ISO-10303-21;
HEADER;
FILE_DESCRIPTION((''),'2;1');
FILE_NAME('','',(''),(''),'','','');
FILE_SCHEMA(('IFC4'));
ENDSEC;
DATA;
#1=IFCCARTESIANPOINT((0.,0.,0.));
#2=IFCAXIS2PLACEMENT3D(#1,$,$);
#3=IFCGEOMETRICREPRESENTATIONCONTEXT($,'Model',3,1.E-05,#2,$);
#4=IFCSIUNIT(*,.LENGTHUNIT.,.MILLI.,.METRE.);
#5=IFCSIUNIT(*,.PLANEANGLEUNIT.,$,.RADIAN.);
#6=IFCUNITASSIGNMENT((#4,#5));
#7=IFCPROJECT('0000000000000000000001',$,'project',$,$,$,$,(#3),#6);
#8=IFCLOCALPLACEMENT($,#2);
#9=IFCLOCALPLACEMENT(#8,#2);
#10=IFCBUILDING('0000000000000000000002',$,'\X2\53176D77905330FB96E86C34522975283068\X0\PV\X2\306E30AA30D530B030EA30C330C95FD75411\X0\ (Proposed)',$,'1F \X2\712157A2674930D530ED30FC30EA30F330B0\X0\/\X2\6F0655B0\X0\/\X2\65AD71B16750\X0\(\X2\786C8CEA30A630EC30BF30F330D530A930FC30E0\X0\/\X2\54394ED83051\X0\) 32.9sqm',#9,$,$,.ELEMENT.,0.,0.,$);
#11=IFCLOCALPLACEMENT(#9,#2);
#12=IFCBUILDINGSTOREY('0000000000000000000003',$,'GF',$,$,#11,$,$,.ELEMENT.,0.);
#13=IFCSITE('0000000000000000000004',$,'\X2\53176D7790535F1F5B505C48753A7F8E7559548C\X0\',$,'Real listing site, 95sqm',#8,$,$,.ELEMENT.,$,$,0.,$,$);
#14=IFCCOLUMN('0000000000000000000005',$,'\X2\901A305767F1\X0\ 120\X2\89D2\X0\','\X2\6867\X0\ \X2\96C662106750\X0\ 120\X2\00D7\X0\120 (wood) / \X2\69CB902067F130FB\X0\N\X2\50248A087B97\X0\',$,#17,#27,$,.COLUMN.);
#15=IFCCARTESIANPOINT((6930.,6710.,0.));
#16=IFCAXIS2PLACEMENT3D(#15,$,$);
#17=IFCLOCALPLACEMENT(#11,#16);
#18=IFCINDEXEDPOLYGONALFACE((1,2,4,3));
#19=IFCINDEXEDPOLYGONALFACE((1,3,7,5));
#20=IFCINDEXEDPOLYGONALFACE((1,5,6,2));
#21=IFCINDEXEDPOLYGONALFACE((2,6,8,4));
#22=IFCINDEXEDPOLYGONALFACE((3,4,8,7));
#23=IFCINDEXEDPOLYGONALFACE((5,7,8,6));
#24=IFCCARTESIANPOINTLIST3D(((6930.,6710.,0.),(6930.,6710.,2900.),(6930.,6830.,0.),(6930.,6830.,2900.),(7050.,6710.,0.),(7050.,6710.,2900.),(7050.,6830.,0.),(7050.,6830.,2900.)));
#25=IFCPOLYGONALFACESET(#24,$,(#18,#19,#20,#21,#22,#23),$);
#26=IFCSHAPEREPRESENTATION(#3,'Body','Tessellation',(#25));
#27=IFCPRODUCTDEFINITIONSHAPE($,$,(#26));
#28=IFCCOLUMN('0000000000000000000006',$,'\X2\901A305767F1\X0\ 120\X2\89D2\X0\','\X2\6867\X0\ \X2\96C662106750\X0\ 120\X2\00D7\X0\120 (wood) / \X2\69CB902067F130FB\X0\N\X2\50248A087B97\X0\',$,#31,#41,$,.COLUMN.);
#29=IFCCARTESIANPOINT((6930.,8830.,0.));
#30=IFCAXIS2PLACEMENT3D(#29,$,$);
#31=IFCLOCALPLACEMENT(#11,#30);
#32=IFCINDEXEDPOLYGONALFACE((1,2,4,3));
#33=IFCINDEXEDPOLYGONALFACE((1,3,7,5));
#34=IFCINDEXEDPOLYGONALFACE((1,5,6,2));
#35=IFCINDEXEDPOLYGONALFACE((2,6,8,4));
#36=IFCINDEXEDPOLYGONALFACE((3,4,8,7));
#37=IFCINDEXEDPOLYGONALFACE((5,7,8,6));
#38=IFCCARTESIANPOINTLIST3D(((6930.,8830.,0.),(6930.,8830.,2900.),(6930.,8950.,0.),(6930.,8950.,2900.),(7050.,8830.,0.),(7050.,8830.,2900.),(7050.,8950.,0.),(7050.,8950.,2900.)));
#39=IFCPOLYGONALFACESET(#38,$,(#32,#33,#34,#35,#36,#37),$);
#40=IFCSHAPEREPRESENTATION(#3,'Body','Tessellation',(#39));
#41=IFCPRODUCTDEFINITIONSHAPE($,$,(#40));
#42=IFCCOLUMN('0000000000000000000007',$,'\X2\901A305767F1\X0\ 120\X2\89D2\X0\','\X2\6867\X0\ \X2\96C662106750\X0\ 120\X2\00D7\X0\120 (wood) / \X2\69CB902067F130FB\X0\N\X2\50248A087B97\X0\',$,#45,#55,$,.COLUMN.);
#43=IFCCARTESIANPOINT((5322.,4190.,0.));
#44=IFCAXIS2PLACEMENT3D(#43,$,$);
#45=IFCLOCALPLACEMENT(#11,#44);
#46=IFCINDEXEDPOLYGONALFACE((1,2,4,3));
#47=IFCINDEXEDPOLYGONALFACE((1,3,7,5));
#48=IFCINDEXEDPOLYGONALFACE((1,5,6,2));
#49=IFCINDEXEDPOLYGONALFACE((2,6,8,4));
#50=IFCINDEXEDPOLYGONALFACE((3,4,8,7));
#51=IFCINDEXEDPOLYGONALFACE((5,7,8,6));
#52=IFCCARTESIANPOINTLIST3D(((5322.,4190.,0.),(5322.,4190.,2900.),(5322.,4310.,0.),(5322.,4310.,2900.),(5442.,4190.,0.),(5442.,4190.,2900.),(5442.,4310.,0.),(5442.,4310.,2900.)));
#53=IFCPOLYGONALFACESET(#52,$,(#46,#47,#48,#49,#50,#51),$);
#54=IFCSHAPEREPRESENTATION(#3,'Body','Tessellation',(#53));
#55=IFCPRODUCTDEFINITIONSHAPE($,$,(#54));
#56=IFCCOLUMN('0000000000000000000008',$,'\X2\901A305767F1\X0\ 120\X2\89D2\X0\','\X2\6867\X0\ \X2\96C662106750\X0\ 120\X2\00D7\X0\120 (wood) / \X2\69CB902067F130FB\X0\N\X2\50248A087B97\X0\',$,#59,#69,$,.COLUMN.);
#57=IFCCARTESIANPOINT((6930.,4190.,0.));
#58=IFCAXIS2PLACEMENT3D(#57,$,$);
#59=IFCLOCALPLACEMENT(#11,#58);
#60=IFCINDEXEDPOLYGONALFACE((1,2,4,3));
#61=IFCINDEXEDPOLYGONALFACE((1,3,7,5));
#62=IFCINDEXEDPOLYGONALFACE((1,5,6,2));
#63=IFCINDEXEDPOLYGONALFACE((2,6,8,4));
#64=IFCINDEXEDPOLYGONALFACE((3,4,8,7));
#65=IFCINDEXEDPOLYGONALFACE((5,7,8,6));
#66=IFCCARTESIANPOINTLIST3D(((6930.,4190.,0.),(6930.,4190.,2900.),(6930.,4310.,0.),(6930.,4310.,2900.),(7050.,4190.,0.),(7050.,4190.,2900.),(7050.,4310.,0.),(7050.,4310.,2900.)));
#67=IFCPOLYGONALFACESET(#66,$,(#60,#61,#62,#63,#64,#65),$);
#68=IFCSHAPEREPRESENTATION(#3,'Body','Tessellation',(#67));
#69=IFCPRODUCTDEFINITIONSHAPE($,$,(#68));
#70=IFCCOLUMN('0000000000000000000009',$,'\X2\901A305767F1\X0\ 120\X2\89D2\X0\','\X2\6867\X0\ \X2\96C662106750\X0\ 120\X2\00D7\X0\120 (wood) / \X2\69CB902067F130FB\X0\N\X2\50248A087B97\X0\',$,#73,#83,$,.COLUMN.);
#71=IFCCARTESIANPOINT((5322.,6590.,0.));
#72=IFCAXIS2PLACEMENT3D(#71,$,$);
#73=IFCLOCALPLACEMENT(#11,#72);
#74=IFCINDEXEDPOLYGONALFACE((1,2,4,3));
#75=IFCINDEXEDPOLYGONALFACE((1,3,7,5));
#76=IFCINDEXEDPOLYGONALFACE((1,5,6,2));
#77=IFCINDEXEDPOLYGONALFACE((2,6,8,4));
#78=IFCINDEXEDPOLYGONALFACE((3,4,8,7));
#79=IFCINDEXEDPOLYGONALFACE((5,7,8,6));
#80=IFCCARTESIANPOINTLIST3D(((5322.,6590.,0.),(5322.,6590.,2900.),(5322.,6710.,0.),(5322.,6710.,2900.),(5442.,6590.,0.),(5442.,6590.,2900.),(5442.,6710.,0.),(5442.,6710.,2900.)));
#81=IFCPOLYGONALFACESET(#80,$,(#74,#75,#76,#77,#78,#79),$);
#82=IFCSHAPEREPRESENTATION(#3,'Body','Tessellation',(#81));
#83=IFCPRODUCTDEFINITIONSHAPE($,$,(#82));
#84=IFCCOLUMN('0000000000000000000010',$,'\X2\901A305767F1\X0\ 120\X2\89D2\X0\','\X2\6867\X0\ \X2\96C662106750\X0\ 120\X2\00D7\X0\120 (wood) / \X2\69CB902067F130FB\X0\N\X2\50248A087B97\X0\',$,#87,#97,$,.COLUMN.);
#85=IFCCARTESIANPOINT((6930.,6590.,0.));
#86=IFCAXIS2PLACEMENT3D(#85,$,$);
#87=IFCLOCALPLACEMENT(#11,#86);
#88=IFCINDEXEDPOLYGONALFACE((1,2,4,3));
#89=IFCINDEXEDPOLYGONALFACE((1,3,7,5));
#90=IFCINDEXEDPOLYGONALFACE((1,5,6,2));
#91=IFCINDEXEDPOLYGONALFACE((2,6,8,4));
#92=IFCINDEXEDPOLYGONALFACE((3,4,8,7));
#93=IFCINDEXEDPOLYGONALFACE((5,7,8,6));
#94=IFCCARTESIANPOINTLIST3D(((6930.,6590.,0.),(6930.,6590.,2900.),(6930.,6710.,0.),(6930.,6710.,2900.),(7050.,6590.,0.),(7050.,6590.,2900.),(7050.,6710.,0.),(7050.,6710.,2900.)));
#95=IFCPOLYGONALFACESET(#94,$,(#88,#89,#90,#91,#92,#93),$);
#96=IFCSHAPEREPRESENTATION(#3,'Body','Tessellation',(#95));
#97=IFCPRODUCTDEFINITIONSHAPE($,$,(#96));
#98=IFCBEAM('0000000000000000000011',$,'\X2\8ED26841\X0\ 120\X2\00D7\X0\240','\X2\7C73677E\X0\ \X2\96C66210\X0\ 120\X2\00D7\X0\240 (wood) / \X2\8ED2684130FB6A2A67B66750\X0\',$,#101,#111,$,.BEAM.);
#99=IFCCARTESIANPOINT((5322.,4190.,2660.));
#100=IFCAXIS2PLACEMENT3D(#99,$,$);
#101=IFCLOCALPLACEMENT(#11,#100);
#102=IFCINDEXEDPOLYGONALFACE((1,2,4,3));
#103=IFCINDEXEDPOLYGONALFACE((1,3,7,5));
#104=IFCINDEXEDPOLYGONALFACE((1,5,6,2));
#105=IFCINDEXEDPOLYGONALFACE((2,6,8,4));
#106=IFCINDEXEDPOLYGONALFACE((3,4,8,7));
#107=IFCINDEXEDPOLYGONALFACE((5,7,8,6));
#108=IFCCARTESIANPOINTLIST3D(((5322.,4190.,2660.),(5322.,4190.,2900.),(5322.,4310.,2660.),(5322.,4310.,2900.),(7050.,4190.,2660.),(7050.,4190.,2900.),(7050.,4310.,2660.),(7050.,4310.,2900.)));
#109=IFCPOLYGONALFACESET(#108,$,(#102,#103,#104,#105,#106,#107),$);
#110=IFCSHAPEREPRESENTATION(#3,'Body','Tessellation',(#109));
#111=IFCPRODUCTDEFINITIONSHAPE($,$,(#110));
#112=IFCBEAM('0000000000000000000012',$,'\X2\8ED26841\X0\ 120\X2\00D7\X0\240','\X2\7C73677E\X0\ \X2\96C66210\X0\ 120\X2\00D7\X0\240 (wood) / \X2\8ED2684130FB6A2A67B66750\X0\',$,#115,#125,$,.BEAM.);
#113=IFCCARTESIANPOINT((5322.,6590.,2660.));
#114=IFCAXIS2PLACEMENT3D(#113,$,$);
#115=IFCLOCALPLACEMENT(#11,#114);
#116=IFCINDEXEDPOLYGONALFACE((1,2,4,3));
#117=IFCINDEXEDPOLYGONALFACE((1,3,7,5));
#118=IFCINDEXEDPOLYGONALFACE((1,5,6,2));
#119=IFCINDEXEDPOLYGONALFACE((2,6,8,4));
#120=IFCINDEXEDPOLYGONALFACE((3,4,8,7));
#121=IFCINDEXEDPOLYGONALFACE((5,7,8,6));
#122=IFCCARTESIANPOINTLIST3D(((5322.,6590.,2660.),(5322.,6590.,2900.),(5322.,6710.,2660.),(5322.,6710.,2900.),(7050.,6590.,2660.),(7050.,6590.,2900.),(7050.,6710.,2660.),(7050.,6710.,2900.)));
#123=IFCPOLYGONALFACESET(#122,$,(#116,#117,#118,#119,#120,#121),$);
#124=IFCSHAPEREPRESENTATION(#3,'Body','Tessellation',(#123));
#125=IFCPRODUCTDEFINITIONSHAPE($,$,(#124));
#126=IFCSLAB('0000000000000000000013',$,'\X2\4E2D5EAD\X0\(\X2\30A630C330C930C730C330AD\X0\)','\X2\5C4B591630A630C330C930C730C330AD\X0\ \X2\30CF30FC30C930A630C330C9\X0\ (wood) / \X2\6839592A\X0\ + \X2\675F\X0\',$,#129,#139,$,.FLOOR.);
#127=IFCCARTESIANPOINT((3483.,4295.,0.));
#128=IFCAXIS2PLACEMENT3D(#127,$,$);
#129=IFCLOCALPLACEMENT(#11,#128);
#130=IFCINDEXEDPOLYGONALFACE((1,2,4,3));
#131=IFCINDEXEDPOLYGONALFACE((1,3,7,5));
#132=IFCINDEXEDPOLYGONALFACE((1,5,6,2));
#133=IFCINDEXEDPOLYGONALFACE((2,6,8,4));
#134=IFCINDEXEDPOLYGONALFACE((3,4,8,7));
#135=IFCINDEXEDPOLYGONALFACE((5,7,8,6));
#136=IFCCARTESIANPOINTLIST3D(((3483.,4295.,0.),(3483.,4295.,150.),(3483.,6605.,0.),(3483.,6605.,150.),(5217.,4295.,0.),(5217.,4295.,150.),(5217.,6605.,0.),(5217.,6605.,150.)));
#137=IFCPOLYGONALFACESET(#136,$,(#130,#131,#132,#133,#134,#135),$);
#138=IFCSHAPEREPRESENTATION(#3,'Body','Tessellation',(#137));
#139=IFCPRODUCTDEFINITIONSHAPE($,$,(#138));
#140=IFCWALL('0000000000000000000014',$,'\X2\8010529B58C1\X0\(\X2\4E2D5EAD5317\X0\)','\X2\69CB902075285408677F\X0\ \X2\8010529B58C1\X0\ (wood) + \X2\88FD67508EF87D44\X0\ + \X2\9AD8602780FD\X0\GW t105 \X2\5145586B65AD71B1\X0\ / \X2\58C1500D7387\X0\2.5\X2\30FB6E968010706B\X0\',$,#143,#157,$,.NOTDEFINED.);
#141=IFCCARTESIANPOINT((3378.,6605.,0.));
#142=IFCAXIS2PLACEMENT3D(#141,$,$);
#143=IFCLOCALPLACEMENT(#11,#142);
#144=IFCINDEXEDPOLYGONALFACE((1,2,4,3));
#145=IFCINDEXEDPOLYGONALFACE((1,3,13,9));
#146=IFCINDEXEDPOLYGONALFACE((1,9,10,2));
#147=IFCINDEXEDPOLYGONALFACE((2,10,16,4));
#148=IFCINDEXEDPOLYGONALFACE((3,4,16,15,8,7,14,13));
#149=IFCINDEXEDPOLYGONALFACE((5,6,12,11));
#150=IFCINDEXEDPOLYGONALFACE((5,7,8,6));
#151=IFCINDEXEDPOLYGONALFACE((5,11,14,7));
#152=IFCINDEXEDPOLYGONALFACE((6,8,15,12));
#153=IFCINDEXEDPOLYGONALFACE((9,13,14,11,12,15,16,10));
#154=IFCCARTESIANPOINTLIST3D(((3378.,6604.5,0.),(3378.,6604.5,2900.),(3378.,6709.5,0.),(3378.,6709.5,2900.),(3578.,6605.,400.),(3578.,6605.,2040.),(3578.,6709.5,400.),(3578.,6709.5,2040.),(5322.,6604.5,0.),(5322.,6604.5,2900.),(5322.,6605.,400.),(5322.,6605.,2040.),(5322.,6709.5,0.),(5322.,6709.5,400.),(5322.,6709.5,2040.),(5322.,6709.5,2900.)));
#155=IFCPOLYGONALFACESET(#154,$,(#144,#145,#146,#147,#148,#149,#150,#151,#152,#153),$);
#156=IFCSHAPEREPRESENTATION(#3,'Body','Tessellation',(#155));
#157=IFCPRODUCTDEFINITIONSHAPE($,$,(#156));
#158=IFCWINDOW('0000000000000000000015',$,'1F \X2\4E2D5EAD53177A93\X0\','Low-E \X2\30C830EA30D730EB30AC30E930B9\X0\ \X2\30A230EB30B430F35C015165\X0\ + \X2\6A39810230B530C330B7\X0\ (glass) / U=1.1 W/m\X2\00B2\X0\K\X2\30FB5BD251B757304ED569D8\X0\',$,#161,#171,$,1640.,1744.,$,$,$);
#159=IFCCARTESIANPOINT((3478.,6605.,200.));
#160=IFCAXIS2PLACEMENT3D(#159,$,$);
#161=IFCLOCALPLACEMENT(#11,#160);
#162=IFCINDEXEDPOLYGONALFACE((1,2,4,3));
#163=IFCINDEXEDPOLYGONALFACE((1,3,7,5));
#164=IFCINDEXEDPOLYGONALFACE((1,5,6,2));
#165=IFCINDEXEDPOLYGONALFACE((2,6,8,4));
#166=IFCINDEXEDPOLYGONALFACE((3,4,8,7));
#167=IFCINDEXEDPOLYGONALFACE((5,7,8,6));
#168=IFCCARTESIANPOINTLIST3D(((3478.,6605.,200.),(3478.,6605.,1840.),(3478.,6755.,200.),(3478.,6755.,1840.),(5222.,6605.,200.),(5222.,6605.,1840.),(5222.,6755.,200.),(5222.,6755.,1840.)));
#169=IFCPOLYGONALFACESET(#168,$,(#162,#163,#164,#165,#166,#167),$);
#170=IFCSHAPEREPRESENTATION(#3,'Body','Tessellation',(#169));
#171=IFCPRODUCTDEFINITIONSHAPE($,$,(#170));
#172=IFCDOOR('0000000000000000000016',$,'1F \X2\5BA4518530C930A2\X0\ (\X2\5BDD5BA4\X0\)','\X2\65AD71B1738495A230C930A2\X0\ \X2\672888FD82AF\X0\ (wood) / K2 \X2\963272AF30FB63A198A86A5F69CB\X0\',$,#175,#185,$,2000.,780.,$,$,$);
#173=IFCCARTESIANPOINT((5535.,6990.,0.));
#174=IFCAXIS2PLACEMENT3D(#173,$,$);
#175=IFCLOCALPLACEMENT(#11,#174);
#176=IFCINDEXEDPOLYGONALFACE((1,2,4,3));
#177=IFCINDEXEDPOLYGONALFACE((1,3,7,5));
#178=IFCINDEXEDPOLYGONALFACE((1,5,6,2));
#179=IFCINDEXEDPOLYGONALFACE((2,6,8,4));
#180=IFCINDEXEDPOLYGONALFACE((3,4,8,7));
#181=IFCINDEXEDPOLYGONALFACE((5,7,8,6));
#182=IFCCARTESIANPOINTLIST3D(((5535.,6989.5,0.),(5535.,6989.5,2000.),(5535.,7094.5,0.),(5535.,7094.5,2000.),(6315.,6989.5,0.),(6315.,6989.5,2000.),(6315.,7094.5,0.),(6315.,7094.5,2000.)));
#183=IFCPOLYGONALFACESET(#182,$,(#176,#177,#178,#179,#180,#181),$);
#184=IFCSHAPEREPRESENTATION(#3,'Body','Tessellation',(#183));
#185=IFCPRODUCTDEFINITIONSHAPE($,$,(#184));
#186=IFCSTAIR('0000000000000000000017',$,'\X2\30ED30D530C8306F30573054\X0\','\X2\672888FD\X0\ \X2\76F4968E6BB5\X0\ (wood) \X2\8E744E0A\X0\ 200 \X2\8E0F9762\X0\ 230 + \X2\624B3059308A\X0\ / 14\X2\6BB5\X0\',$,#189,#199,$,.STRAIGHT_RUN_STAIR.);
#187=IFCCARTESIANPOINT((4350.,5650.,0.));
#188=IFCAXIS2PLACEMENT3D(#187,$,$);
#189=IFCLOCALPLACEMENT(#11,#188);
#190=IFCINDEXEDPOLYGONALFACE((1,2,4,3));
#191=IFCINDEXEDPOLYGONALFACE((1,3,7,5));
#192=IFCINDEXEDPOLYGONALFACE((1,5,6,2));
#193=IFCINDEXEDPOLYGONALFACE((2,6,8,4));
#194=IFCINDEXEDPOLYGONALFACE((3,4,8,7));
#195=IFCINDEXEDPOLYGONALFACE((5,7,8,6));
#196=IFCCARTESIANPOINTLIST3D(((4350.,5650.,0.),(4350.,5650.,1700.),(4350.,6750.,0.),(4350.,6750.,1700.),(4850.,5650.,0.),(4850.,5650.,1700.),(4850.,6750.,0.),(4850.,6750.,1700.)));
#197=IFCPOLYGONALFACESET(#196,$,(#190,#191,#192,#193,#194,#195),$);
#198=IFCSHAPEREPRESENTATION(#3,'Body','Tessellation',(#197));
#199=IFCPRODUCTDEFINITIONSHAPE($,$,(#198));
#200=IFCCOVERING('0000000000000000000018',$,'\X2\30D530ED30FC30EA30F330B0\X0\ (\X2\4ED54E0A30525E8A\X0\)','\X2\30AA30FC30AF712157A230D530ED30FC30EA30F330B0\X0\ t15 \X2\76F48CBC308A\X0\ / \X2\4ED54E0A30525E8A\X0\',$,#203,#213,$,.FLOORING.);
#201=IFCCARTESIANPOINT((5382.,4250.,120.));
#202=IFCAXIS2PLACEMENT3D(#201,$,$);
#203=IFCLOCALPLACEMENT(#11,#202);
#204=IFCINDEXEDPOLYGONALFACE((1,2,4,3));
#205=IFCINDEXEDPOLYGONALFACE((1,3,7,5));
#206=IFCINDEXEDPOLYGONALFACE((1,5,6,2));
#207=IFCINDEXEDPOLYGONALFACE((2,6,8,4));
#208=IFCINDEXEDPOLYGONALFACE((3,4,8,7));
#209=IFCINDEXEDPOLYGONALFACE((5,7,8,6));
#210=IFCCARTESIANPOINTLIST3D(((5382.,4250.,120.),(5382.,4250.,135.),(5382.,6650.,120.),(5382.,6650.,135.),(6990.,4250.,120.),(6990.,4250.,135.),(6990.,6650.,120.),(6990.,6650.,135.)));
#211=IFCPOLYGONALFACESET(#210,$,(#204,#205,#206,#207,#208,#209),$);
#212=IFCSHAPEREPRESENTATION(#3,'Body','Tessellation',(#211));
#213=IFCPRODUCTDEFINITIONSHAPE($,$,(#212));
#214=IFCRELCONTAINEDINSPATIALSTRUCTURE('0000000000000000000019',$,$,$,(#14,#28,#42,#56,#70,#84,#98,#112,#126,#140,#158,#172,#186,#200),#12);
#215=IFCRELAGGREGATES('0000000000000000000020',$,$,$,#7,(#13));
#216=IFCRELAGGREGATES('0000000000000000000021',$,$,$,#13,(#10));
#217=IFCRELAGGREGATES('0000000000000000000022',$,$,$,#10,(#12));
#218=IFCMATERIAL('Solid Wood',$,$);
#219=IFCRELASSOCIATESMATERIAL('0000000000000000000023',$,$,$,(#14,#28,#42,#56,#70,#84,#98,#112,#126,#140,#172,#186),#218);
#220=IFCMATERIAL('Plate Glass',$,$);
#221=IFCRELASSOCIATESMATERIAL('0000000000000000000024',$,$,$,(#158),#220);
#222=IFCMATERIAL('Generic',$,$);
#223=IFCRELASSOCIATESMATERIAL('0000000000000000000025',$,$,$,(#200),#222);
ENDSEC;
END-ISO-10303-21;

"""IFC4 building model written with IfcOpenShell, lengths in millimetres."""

from ifc_helpers import new_model, si_unit, frame, frame_2d, origin, place, context, project, spatial, rectangle, extrude, material, element, fill, save


model = new_model("IFC4")

# Units and contexts
model_context = context("Model", 3, precision=1e-05, world=origin())
ifc_project = project(units=[si_unit("LENGTHUNIT", "METRE", prefix="MILLI"), si_unit("PLANEANGLEUNIT", "RADIAN")], contexts=[model_context])

# Site, building, storey
site_placement = place(None, origin())
site = spatial("IfcSite", under=ifc_project, at=site_placement, Name="北海道弟子屈町美留和", ObjectType="Real listing site, 95sqm", CompositionType="ELEMENT", RefElevation=0.0)
building_placement = place(site_placement, origin())
building = spatial("IfcBuilding", under=site, at=building_placement, Name="北海道・雨水利用とPVのオフグリッド志向 (Proposed)", ObjectType="1F 無垢杉フローリング/漆喰/断熱材(硬質ウレタンフォーム/吹付け) 32.9sqm", CompositionType="ELEMENT", ElevationOfRefHeight=0.0, ElevationOfTerrain=0.0)
storey_placement = place(building_placement, origin())
storey = spatial("IfcBuildingStorey", under=building, at=storey_placement, Name="GF", CompositionType="ELEMENT", Elevation=0.0)

# Columns
ifc_material_1 = material(Name="Solid Wood")
column_1_placement = place(storey_placement, frame((6930.0, 6710.0, 0.0)))
element("IfcColumn", 1, at=column_1_placement, inside=storey, material=ifc_material_1, Name="通し柱 120角", Description="桧 集成材 120×120 (wood) / 構造柱・N値計算", PredefinedType="COLUMN", context=model_context, shape_type="SweptSolid", body=[
    extrude(rectangle(XDim=120.0, YDim=120.0, at=frame_2d((60.0, 60.0))), frame((6930.0, 6710.0, 0.0)), (0.0, 0.0, 1.0), 2900.0),
])
column_2_placement = place(storey_placement, frame((6930.0, 8830.0, 0.0)))
element("IfcColumn", 2, at=column_2_placement, inside=storey, material=ifc_material_1, Name="通し柱 120角", Description="桧 集成材 120×120 (wood) / 構造柱・N値計算", PredefinedType="COLUMN", context=model_context, shape_type="SweptSolid", body=[
    extrude(rectangle(XDim=120.0, YDim=120.0, at=frame_2d((60.0, 60.0))), frame((6930.0, 8830.0, 0.0)), (0.0, 0.0, 1.0), 2900.0),
])
column_3_placement = place(storey_placement, frame((5322.0, 4190.0, 0.0)))
element("IfcColumn", 3, at=column_3_placement, inside=storey, material=ifc_material_1, Name="通し柱 120角", Description="桧 集成材 120×120 (wood) / 構造柱・N値計算", PredefinedType="COLUMN", context=model_context, shape_type="SweptSolid", body=[
    extrude(rectangle(XDim=120.0, YDim=120.0, at=frame_2d((60.0, 60.0))), frame((5322.0, 4190.0, 0.0)), (0.0, 0.0, 1.0), 2900.0),
])
column_4_placement = place(storey_placement, frame((6930.0, 4190.0, 0.0)))
element("IfcColumn", 4, at=column_4_placement, inside=storey, material=ifc_material_1, Name="通し柱 120角", Description="桧 集成材 120×120 (wood) / 構造柱・N値計算", PredefinedType="COLUMN", context=model_context, shape_type="SweptSolid", body=[
    extrude(rectangle(XDim=120.0, YDim=120.0, at=frame_2d((60.0, 60.0))), frame((6930.0, 4190.0, 0.0)), (0.0, 0.0, 1.0), 2900.0),
])
column_5_placement = place(storey_placement, frame((5322.0, 6590.0, 0.0)))
element("IfcColumn", 5, at=column_5_placement, inside=storey, material=ifc_material_1, Name="通し柱 120角", Description="桧 集成材 120×120 (wood) / 構造柱・N値計算", PredefinedType="COLUMN", context=model_context, shape_type="SweptSolid", body=[
    extrude(rectangle(XDim=120.0, YDim=120.0, at=frame_2d((60.0, 60.0))), frame((5322.0, 6590.0, 0.0)), (0.0, 0.0, 1.0), 2900.0),
])
column_6_placement = place(storey_placement, frame((6930.0, 6590.0, 0.0)))
element("IfcColumn", 6, at=column_6_placement, inside=storey, material=ifc_material_1, Name="通し柱 120角", Description="桧 集成材 120×120 (wood) / 構造柱・N値計算", PredefinedType="COLUMN", context=model_context, shape_type="SweptSolid", body=[
    extrude(rectangle(XDim=120.0, YDim=120.0, at=frame_2d((60.0, 60.0))), frame((6930.0, 6590.0, 0.0)), (0.0, 0.0, 1.0), 2900.0),
])

# Beams
beam_1_placement = place(storey_placement, frame((5322.0, 4190.0, 2660.0)))
element("IfcBeam", 7, at=beam_1_placement, inside=storey, material=ifc_material_1, Name="軒桁 120×240", Description="米松 集成 120×240 (wood) / 軒桁・横架材", PredefinedType="BEAM", context=model_context, shape_type="SweptSolid", body=[
    extrude(rectangle(XDim=1728.0, YDim=120.0, at=frame_2d((864.0, 60.0))), frame((5322.0, 4190.0, 2660.0)), (0.0, 0.0, 1.0), 240.0),
])
beam_2_placement = place(storey_placement, frame((5322.0, 6590.0, 2660.0)))
element("IfcBeam", 8, at=beam_2_placement, inside=storey, material=ifc_material_1, Name="軒桁 120×240", Description="米松 集成 120×240 (wood) / 軒桁・横架材", PredefinedType="BEAM", context=model_context, shape_type="SweptSolid", body=[
    extrude(rectangle(XDim=1728.0, YDim=120.0, at=frame_2d((864.0, 60.0))), frame((5322.0, 6590.0, 2660.0)), (0.0, 0.0, 1.0), 240.0),
])

# Slab
slab_placement = place(storey_placement, frame((3483.0, 4295.0, 0.0)))
element("IfcSlab", 9, at=slab_placement, inside=storey, material=ifc_material_1, Name="中庭(ウッドデッキ)", Description="屋外ウッドデッキ ハードウッド (wood) / 根太 + 束", PredefinedType="FLOOR", context=model_context, shape_type="SweptSolid", body=[
    extrude(rectangle(XDim=1734.0, YDim=2310.0, at=frame_2d((867.0, 1155.0))), frame((3483.0, 4295.0, 0.0)), (0.0, 0.0, 1.0), 150.0),
])

# Wall, opening, window
wall_1_placement = place(storey_placement, frame((3378.0, 6605.0, 0.0)))
wall_1 = element("IfcWall", 10, at=wall_1_placement, inside=storey, material=ifc_material_1, Name="耐力壁(中庭北)", Description="構造用合板 耐力壁 (wood) + 製材軸組 + 高性能GW t105 充填断熱 / 壁倍率2.5・準耐火", PredefinedType="NOTDEFINED", context=model_context, shape_type="SweptSolid", body=[
    extrude(rectangle(XDim=1944.0, YDim=105.0, at=frame_2d((972.0, 52.0))), frame((3378.0, 6605.0, 0.0)), (0.0, 0.0, 1.0), 2900.0),
])
opening_placement = place(storey_placement, frame((3478.0, 6605.0, 200.0)))
opening = element("IfcOpeningElement", 11, at=opening_placement, cuts=wall_1, PredefinedType="NOTDEFINED", context=model_context, shape_type="SweptSolid", body=[
    extrude(rectangle(XDim=1744.0, YDim=150.0, at=frame_2d((872.0, 75.0))), frame((3478.0, 6605.0, 200.0)), (0.0, 0.0, 1.0), 1640.0),
])
ifc_material_2 = material(Name="Plate Glass")
window_placement = place(storey_placement, frame((3478.0, 6605.0, 200.0)))
window = element("IfcWindow", 12, at=window_placement, inside=storey, material=ifc_material_2, Name="1F 中庭北窓", Description="Low-E トリプルガラス アルゴン封入 + 樹脂サッシ (glass) / U=1.1 W/m²K・寒冷地仕様", OverallHeight=1640.0, OverallWidth=1744.0, context=model_context, shape_type="SweptSolid", body=[
    extrude(rectangle(XDim=1744.0, YDim=150.0, at=frame_2d((872.0, 75.0))), frame((3478.0, 6605.0, 200.0)), (0.0, 0.0, 1.0), 1640.0),
])
fill(opening, window)

# Door
door_placement = place(storey_placement, frame((5535.0, 6990.0, 0.0)))
element("IfcDoor", 13, at=door_placement, inside=storey, material=ifc_material_1, Name="1F 室内ドア (寝室)", Description="断熱玄関ドア 木製芯 (wood) / K2 防犯・採風機構", OverallHeight=2000.0, OverallWidth=780.0, context=model_context, shape_type="SweptSolid", body=[
    extrude(rectangle(XDim=780.0, YDim=105.0, at=frame_2d((390.0, 52.0))), frame((5535.0, 6990.0, 0.0)), (0.0, 0.0, 1.0), 2000.0),
])

# Stair
stair_placement = place(storey_placement, frame((4350.0, 5650.0, 0.0)))
element("IfcStair", 14, at=stair_placement, inside=storey, material=ifc_material_1, Name="ロフトはしご", Description="木製 直階段 (wood) 蹴上 200 踏面 230 + 手すり / 14段", PredefinedType="STRAIGHT_RUN_STAIR", context=model_context, shape_type="SweptSolid", body=[
    extrude(rectangle(XDim=500.0, YDim=1100.0, at=frame_2d((250.0, 550.0))), frame((4350.0, 5650.0, 0.0)), (0.0, 0.0, 1.0), 1700.0),
])

# Covering
ifc_material_3 = material(Name="Generic")
covering_placement = place(storey_placement, frame((5382.0, 4250.0, 120.0)))
element("IfcCovering", 15, at=covering_placement, inside=storey, material=ifc_material_3, Name="フローリング (仕上げ床)", Description="オーク無垢フローリング t15 直貼り / 仕上げ床", PredefinedType="FLOORING", context=model_context, shape_type="SweptSolid", body=[
    extrude(rectangle(XDim=1608.0, YDim=2400.0, at=frame_2d((804.0, 1200.0))), frame((5382.0, 4250.0, 120.0)), (0.0, 0.0, 1.0), 15.0),
])

save(model, "model.ifc")
